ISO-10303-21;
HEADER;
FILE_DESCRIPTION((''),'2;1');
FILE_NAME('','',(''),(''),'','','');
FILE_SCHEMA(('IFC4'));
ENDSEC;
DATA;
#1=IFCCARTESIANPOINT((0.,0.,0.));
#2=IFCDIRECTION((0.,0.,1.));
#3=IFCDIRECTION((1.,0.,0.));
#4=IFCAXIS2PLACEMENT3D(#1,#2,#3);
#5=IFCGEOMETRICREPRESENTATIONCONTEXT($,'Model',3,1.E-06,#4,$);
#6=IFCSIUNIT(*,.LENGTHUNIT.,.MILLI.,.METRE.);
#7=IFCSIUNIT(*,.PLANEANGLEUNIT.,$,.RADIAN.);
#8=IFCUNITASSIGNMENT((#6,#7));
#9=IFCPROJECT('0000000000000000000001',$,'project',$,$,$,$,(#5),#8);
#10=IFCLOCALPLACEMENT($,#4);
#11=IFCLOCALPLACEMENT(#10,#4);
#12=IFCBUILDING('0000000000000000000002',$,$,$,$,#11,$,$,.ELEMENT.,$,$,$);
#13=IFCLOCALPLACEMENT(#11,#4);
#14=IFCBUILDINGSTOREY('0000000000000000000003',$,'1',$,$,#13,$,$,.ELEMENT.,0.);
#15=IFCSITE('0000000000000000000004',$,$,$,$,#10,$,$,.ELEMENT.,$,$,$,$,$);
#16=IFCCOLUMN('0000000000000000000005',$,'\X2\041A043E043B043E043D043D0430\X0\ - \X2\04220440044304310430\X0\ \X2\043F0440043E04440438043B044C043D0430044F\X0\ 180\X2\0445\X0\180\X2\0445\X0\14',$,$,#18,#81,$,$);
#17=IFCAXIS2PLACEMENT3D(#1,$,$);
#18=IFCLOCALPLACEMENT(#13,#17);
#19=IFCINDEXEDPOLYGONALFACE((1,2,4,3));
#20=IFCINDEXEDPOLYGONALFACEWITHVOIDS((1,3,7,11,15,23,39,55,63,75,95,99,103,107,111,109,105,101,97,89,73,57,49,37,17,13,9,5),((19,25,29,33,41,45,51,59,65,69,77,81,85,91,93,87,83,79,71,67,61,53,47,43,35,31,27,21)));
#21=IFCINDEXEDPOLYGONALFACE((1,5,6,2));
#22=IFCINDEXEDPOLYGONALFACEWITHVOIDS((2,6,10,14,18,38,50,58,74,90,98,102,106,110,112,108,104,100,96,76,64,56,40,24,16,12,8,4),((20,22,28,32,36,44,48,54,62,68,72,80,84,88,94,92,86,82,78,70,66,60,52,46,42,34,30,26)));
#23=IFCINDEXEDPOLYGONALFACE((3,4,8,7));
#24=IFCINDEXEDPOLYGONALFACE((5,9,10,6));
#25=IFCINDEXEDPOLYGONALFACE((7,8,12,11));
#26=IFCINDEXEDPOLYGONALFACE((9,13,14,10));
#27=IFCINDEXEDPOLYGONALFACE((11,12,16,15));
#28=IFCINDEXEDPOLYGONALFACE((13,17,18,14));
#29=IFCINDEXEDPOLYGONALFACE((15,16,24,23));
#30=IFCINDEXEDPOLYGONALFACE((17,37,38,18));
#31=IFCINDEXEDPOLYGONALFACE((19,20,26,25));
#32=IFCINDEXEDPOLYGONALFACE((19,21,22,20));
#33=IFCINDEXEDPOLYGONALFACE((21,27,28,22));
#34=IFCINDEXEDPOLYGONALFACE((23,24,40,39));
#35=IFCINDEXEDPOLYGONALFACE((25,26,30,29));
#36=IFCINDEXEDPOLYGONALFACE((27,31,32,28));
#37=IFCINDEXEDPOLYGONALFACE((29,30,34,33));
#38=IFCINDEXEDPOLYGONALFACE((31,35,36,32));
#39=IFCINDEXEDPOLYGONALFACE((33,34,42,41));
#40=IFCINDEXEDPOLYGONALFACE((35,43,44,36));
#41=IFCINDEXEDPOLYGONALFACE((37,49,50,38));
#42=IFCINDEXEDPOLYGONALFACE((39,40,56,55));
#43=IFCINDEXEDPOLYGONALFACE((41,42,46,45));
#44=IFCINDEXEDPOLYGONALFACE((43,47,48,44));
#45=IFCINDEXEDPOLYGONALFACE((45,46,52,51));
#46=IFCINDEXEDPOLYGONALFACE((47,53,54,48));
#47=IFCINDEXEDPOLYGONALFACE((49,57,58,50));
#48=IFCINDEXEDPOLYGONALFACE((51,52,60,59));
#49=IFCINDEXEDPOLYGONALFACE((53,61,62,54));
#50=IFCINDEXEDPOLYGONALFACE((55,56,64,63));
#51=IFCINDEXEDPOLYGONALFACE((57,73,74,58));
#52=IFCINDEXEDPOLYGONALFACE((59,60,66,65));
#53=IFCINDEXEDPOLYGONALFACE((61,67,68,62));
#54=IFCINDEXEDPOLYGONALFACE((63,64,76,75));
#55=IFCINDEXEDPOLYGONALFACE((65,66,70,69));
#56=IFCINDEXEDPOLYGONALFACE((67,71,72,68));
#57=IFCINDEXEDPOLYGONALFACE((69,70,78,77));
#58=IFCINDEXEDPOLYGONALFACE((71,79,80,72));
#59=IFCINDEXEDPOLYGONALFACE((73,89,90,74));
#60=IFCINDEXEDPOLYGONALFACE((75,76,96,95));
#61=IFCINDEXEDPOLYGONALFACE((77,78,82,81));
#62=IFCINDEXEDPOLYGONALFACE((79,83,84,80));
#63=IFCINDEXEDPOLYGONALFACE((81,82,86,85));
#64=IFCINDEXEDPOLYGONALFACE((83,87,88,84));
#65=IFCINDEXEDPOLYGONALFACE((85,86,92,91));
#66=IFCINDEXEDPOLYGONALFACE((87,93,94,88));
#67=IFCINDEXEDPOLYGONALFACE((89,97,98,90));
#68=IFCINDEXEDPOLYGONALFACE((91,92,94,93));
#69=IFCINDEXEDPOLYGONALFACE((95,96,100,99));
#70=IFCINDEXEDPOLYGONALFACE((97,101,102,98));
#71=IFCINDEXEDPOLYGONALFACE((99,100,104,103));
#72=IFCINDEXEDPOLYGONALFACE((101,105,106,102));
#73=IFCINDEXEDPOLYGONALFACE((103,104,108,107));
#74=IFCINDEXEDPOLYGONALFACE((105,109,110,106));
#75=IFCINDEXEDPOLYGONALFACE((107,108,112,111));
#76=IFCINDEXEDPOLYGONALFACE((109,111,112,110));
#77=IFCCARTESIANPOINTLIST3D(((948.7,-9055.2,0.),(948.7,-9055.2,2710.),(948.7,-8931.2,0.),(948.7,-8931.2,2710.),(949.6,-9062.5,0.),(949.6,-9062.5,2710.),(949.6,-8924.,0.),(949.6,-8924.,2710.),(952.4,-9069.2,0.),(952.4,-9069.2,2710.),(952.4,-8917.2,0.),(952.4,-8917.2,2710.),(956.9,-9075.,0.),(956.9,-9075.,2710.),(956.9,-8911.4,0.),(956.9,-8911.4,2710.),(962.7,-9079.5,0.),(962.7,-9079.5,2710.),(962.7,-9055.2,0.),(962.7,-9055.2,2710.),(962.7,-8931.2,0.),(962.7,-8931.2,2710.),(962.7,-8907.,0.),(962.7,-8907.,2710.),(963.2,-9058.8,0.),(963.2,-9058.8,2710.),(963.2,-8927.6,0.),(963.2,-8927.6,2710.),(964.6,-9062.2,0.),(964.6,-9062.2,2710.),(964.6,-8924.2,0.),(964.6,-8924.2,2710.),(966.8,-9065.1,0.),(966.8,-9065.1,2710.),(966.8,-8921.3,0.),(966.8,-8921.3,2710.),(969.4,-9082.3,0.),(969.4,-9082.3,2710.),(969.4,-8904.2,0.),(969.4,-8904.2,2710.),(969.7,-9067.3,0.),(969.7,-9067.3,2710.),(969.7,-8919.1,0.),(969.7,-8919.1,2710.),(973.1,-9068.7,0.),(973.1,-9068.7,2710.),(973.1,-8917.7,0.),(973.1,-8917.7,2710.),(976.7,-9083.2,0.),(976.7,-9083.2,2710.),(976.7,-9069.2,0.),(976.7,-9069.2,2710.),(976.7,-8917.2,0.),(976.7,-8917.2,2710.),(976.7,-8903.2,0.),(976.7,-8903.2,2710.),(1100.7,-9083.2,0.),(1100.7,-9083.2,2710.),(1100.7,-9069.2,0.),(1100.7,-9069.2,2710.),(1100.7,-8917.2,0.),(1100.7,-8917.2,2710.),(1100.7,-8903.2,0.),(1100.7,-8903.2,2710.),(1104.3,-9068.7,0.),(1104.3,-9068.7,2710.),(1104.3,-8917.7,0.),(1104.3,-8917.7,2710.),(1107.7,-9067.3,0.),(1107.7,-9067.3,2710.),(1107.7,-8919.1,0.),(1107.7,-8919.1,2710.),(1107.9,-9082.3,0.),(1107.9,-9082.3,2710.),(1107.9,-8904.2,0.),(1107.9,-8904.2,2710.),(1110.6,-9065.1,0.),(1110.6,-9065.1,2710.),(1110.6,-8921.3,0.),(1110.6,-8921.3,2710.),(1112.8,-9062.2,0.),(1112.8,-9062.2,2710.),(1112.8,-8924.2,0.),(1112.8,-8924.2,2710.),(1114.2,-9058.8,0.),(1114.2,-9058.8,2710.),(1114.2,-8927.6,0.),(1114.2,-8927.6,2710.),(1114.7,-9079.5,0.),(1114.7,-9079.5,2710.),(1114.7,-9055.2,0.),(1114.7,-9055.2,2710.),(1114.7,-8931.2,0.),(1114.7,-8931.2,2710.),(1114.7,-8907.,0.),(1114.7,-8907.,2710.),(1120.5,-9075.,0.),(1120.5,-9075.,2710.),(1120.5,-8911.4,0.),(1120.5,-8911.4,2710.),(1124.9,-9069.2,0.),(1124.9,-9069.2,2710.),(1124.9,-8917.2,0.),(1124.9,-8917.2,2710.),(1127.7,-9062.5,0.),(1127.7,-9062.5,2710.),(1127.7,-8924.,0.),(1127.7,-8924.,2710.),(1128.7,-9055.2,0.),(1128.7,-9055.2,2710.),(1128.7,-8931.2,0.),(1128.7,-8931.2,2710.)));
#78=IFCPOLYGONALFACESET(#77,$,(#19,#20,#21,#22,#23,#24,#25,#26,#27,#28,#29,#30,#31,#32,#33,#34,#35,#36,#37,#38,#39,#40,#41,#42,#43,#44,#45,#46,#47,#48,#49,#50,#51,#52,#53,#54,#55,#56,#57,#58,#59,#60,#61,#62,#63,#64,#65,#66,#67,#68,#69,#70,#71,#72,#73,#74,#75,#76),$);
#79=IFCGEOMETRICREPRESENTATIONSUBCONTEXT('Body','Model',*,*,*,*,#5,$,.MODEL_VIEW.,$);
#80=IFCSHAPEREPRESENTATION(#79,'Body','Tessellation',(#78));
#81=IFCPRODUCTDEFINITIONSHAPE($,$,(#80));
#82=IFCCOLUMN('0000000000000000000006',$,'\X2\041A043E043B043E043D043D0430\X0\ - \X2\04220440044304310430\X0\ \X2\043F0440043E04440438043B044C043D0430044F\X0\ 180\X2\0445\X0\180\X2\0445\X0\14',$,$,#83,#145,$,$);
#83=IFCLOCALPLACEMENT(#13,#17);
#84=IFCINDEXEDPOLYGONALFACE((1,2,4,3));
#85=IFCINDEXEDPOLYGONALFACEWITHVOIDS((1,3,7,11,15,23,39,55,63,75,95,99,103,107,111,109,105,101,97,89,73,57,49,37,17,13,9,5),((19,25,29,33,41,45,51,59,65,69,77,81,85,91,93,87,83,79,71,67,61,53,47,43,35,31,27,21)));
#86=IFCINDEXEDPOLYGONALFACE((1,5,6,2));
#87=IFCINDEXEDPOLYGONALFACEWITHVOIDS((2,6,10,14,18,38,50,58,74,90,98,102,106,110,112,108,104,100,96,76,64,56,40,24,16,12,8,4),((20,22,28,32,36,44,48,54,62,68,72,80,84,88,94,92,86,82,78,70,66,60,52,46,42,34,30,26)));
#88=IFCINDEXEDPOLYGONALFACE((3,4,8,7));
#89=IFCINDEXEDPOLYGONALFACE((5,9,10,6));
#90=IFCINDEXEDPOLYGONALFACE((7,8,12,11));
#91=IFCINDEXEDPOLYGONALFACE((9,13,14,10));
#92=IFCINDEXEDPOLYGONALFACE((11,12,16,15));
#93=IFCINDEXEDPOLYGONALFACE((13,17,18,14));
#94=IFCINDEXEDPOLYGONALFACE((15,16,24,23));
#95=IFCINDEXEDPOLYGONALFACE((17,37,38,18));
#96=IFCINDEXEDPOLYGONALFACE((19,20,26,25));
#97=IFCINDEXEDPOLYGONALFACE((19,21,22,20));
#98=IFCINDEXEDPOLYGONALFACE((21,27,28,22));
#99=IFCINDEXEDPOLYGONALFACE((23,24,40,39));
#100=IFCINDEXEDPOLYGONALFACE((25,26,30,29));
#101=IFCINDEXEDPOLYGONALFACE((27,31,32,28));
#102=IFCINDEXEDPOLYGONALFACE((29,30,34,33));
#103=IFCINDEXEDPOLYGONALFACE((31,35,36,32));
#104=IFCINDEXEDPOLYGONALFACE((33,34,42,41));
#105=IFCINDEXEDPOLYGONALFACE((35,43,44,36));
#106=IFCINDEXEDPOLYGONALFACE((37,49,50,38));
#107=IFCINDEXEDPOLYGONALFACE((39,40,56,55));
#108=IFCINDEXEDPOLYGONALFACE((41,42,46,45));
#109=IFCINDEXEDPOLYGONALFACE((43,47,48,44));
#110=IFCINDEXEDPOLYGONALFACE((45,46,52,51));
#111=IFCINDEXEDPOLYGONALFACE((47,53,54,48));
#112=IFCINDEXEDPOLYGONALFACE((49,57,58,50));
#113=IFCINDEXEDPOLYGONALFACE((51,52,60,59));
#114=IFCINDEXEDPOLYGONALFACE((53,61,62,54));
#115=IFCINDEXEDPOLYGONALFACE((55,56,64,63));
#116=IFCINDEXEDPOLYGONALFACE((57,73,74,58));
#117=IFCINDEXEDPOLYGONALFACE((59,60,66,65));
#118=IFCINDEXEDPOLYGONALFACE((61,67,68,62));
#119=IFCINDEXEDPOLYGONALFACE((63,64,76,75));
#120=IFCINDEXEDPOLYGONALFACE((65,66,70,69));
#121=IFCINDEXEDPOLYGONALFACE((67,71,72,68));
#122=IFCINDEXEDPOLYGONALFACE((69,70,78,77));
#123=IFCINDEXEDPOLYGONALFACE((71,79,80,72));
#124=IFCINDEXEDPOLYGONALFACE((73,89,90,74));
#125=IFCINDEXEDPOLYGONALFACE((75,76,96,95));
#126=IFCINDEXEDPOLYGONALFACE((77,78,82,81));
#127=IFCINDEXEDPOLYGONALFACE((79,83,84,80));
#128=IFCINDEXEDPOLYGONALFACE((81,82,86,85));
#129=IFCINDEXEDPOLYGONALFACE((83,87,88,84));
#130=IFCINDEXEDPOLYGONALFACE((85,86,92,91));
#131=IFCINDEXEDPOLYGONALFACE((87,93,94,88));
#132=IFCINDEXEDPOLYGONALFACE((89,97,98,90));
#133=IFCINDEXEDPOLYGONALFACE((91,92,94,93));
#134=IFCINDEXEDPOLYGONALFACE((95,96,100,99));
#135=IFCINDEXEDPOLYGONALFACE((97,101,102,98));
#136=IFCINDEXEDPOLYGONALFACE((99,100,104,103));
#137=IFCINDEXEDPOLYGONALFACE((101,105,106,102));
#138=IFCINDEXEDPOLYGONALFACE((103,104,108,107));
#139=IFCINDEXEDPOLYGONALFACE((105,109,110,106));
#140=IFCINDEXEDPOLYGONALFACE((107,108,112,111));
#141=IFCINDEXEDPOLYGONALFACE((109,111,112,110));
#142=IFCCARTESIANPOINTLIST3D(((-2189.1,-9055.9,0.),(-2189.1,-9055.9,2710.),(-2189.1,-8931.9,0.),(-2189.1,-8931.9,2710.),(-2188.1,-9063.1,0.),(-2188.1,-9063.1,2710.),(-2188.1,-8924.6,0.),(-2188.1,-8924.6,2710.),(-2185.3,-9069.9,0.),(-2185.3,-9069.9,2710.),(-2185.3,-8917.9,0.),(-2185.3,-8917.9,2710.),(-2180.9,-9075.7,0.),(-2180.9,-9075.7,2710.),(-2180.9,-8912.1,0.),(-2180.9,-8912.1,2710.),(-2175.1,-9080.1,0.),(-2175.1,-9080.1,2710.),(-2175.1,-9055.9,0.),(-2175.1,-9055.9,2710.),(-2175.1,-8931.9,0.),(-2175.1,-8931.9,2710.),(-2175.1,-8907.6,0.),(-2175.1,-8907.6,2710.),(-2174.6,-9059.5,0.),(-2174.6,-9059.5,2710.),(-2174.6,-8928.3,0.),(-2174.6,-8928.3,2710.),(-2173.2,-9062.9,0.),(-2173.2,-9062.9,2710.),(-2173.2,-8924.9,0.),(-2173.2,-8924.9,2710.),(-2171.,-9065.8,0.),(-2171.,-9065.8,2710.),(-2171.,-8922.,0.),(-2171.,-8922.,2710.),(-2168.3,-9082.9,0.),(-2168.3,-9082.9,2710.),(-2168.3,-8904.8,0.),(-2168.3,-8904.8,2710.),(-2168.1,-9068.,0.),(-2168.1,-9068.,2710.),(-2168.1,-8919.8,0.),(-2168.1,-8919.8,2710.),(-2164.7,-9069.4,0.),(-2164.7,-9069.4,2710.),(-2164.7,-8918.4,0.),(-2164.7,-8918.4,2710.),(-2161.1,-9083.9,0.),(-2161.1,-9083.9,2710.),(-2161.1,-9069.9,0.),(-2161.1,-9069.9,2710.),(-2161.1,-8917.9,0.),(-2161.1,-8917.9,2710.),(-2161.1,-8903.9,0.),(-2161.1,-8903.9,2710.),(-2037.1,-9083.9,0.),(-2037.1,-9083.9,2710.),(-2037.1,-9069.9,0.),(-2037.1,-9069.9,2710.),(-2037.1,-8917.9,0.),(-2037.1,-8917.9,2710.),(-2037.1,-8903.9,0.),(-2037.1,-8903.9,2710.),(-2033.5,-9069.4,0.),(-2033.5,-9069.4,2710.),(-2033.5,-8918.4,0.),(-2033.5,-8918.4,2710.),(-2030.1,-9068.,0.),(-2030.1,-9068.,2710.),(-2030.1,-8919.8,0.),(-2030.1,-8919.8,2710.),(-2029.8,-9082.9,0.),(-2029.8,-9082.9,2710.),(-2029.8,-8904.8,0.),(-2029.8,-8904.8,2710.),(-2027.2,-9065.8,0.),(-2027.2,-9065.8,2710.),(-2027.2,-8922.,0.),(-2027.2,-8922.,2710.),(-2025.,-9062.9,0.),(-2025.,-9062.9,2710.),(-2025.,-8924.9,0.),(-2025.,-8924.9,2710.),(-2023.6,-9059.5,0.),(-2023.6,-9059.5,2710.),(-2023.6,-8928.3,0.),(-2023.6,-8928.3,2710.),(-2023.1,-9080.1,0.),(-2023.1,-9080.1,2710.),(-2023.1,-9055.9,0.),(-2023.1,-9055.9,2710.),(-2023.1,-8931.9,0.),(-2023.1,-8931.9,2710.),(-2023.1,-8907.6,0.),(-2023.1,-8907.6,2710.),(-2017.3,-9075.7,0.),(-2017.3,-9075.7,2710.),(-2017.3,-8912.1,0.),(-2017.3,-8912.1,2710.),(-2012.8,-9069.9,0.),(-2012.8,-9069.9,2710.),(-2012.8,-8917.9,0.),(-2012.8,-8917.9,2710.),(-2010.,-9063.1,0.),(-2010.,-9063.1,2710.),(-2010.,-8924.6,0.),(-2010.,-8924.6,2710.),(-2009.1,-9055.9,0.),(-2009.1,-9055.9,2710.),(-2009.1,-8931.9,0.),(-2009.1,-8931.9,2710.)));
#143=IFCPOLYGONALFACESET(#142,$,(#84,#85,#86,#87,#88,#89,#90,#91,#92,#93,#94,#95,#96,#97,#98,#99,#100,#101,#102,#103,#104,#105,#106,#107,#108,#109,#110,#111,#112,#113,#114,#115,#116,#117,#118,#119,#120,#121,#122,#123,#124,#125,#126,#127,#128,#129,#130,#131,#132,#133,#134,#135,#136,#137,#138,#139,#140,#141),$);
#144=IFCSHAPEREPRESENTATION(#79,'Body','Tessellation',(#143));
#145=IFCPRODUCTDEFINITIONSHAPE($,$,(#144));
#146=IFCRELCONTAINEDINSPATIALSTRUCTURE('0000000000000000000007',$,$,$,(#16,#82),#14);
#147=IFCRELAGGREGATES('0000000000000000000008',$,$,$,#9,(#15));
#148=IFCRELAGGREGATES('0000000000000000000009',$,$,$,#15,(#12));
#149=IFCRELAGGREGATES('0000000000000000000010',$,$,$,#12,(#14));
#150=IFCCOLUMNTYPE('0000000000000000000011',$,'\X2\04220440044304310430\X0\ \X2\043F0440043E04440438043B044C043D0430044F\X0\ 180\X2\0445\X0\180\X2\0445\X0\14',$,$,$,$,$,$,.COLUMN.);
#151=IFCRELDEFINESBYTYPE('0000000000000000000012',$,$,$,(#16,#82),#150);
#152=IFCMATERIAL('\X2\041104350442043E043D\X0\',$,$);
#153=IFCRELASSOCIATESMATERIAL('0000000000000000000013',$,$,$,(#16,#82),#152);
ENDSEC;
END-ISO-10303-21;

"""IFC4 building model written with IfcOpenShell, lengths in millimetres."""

from ifc_helpers import new_model, si_unit, frame, origin_with_axes, place, context, subcontext, project, spatial, line, arc, indexed_curve, outline, extrude, source, transform, mapped, material, type_object, element, save


model = new_model("IFC4")

# Units and contexts
model_context = context("Model", 3, precision=1e-06, world=origin_with_axes())
body_context = subcontext(model_context, "Body", "Model", "MODEL_VIEW")
ifc_project = project(units=[si_unit("LENGTHUNIT", "METRE", prefix="MILLI"), si_unit("PLANEANGLEUNIT", "RADIAN")], contexts=[model_context])

# Site, building, storey
site_placement = place(None, origin_with_axes())
site = spatial("IfcSite", under=ifc_project, at=site_placement, CompositionType="ELEMENT")
building_placement = place(site_placement, origin_with_axes())
building = spatial("IfcBuilding", under=site, at=building_placement, CompositionType="ELEMENT")
storey_placement = place(building_placement, origin_with_axes())
storey = spatial("IfcBuildingStorey", under=building, at=storey_placement, Name="1", CompositionType="ELEMENT", Elevation=0.0)

# Columns
ifc_material = material(Name="Бетон")
column_type = type_object("IfcColumnType", Name="Труба профильная 180х180х14", PredefinedType="COLUMN")
shared_shape = source(origin_with_axes(), body_context, "Body", "SweptSolid", [
    extrude(outline(indexed_curve([(-90.0, -62.0), (-81.8, -81.8), (-62.0, -90.0), (62.0, -90.0), (81.8, -81.8), (90.0, -62.0), (90.0, 62.0), (81.8, 81.8), (62.0, 90.0), (-62.0, 90.0), (-81.8, 81.8), (-90.0, 62.0)], segments=[arc(1, 2, 3), line(3, 4), arc(4, 5, 6), line(6, 7), arc(7, 8, 9), line(9, 10), arc(10, 11, 12), line(12, 1)]), holes=[indexed_curve([(-76.0, 62.0), (-71.9, 71.9), (-62.0, 76.0), (62.0, 76.0), (71.9, 71.9), (76.0, 62.0), (76.0, -62.0), (71.9, -71.9), (62.0, -76.0), (-62.0, -76.0), (-71.9, -71.9), (-76.0, -62.0)], segments=[arc(1, 2, 3), line(3, 4), arc(4, 5, 6), line(6, 7), arc(7, 8, 9), line(9, 10), arc(10, 11, 12), line(12, 1)])]), origin_with_axes(), (0.0, 0.0, 1.0), 2710.0),
])
for number, where, z_axis, x_axis, name in (
    (1, (1038.7, -8993.2, 0.0), (0.0, 0.0, 1.0), (1.0, 0.0, 0.0), "Колонна - Труба профильная 180х180х14"),
    (2, (-2099.1, -8993.9, 0.0), (0.0, 0.0, 1.0), (1.0, 0.0, 0.0), "Колонна - Труба профильная 180х180х14"),
):
    element("IfcColumn", number, at=place(storey_placement, frame(where, z_axis=z_axis, x_axis=x_axis)), inside=storey, type_object=column_type, material=ifc_material, Name=name, context=body_context, shape_type="MappedRepresentation", body=[
        mapped(shared_shape, transform((0.0, 0.0, 0.0), x_axis=(1.0, 0.0, 0.0), y_axis=(0.0, 1.0, 0.0), z_axis=(0.0, 0.0, 1.0), scale=1.0)),
    ])

save(model, "model.ifc")
